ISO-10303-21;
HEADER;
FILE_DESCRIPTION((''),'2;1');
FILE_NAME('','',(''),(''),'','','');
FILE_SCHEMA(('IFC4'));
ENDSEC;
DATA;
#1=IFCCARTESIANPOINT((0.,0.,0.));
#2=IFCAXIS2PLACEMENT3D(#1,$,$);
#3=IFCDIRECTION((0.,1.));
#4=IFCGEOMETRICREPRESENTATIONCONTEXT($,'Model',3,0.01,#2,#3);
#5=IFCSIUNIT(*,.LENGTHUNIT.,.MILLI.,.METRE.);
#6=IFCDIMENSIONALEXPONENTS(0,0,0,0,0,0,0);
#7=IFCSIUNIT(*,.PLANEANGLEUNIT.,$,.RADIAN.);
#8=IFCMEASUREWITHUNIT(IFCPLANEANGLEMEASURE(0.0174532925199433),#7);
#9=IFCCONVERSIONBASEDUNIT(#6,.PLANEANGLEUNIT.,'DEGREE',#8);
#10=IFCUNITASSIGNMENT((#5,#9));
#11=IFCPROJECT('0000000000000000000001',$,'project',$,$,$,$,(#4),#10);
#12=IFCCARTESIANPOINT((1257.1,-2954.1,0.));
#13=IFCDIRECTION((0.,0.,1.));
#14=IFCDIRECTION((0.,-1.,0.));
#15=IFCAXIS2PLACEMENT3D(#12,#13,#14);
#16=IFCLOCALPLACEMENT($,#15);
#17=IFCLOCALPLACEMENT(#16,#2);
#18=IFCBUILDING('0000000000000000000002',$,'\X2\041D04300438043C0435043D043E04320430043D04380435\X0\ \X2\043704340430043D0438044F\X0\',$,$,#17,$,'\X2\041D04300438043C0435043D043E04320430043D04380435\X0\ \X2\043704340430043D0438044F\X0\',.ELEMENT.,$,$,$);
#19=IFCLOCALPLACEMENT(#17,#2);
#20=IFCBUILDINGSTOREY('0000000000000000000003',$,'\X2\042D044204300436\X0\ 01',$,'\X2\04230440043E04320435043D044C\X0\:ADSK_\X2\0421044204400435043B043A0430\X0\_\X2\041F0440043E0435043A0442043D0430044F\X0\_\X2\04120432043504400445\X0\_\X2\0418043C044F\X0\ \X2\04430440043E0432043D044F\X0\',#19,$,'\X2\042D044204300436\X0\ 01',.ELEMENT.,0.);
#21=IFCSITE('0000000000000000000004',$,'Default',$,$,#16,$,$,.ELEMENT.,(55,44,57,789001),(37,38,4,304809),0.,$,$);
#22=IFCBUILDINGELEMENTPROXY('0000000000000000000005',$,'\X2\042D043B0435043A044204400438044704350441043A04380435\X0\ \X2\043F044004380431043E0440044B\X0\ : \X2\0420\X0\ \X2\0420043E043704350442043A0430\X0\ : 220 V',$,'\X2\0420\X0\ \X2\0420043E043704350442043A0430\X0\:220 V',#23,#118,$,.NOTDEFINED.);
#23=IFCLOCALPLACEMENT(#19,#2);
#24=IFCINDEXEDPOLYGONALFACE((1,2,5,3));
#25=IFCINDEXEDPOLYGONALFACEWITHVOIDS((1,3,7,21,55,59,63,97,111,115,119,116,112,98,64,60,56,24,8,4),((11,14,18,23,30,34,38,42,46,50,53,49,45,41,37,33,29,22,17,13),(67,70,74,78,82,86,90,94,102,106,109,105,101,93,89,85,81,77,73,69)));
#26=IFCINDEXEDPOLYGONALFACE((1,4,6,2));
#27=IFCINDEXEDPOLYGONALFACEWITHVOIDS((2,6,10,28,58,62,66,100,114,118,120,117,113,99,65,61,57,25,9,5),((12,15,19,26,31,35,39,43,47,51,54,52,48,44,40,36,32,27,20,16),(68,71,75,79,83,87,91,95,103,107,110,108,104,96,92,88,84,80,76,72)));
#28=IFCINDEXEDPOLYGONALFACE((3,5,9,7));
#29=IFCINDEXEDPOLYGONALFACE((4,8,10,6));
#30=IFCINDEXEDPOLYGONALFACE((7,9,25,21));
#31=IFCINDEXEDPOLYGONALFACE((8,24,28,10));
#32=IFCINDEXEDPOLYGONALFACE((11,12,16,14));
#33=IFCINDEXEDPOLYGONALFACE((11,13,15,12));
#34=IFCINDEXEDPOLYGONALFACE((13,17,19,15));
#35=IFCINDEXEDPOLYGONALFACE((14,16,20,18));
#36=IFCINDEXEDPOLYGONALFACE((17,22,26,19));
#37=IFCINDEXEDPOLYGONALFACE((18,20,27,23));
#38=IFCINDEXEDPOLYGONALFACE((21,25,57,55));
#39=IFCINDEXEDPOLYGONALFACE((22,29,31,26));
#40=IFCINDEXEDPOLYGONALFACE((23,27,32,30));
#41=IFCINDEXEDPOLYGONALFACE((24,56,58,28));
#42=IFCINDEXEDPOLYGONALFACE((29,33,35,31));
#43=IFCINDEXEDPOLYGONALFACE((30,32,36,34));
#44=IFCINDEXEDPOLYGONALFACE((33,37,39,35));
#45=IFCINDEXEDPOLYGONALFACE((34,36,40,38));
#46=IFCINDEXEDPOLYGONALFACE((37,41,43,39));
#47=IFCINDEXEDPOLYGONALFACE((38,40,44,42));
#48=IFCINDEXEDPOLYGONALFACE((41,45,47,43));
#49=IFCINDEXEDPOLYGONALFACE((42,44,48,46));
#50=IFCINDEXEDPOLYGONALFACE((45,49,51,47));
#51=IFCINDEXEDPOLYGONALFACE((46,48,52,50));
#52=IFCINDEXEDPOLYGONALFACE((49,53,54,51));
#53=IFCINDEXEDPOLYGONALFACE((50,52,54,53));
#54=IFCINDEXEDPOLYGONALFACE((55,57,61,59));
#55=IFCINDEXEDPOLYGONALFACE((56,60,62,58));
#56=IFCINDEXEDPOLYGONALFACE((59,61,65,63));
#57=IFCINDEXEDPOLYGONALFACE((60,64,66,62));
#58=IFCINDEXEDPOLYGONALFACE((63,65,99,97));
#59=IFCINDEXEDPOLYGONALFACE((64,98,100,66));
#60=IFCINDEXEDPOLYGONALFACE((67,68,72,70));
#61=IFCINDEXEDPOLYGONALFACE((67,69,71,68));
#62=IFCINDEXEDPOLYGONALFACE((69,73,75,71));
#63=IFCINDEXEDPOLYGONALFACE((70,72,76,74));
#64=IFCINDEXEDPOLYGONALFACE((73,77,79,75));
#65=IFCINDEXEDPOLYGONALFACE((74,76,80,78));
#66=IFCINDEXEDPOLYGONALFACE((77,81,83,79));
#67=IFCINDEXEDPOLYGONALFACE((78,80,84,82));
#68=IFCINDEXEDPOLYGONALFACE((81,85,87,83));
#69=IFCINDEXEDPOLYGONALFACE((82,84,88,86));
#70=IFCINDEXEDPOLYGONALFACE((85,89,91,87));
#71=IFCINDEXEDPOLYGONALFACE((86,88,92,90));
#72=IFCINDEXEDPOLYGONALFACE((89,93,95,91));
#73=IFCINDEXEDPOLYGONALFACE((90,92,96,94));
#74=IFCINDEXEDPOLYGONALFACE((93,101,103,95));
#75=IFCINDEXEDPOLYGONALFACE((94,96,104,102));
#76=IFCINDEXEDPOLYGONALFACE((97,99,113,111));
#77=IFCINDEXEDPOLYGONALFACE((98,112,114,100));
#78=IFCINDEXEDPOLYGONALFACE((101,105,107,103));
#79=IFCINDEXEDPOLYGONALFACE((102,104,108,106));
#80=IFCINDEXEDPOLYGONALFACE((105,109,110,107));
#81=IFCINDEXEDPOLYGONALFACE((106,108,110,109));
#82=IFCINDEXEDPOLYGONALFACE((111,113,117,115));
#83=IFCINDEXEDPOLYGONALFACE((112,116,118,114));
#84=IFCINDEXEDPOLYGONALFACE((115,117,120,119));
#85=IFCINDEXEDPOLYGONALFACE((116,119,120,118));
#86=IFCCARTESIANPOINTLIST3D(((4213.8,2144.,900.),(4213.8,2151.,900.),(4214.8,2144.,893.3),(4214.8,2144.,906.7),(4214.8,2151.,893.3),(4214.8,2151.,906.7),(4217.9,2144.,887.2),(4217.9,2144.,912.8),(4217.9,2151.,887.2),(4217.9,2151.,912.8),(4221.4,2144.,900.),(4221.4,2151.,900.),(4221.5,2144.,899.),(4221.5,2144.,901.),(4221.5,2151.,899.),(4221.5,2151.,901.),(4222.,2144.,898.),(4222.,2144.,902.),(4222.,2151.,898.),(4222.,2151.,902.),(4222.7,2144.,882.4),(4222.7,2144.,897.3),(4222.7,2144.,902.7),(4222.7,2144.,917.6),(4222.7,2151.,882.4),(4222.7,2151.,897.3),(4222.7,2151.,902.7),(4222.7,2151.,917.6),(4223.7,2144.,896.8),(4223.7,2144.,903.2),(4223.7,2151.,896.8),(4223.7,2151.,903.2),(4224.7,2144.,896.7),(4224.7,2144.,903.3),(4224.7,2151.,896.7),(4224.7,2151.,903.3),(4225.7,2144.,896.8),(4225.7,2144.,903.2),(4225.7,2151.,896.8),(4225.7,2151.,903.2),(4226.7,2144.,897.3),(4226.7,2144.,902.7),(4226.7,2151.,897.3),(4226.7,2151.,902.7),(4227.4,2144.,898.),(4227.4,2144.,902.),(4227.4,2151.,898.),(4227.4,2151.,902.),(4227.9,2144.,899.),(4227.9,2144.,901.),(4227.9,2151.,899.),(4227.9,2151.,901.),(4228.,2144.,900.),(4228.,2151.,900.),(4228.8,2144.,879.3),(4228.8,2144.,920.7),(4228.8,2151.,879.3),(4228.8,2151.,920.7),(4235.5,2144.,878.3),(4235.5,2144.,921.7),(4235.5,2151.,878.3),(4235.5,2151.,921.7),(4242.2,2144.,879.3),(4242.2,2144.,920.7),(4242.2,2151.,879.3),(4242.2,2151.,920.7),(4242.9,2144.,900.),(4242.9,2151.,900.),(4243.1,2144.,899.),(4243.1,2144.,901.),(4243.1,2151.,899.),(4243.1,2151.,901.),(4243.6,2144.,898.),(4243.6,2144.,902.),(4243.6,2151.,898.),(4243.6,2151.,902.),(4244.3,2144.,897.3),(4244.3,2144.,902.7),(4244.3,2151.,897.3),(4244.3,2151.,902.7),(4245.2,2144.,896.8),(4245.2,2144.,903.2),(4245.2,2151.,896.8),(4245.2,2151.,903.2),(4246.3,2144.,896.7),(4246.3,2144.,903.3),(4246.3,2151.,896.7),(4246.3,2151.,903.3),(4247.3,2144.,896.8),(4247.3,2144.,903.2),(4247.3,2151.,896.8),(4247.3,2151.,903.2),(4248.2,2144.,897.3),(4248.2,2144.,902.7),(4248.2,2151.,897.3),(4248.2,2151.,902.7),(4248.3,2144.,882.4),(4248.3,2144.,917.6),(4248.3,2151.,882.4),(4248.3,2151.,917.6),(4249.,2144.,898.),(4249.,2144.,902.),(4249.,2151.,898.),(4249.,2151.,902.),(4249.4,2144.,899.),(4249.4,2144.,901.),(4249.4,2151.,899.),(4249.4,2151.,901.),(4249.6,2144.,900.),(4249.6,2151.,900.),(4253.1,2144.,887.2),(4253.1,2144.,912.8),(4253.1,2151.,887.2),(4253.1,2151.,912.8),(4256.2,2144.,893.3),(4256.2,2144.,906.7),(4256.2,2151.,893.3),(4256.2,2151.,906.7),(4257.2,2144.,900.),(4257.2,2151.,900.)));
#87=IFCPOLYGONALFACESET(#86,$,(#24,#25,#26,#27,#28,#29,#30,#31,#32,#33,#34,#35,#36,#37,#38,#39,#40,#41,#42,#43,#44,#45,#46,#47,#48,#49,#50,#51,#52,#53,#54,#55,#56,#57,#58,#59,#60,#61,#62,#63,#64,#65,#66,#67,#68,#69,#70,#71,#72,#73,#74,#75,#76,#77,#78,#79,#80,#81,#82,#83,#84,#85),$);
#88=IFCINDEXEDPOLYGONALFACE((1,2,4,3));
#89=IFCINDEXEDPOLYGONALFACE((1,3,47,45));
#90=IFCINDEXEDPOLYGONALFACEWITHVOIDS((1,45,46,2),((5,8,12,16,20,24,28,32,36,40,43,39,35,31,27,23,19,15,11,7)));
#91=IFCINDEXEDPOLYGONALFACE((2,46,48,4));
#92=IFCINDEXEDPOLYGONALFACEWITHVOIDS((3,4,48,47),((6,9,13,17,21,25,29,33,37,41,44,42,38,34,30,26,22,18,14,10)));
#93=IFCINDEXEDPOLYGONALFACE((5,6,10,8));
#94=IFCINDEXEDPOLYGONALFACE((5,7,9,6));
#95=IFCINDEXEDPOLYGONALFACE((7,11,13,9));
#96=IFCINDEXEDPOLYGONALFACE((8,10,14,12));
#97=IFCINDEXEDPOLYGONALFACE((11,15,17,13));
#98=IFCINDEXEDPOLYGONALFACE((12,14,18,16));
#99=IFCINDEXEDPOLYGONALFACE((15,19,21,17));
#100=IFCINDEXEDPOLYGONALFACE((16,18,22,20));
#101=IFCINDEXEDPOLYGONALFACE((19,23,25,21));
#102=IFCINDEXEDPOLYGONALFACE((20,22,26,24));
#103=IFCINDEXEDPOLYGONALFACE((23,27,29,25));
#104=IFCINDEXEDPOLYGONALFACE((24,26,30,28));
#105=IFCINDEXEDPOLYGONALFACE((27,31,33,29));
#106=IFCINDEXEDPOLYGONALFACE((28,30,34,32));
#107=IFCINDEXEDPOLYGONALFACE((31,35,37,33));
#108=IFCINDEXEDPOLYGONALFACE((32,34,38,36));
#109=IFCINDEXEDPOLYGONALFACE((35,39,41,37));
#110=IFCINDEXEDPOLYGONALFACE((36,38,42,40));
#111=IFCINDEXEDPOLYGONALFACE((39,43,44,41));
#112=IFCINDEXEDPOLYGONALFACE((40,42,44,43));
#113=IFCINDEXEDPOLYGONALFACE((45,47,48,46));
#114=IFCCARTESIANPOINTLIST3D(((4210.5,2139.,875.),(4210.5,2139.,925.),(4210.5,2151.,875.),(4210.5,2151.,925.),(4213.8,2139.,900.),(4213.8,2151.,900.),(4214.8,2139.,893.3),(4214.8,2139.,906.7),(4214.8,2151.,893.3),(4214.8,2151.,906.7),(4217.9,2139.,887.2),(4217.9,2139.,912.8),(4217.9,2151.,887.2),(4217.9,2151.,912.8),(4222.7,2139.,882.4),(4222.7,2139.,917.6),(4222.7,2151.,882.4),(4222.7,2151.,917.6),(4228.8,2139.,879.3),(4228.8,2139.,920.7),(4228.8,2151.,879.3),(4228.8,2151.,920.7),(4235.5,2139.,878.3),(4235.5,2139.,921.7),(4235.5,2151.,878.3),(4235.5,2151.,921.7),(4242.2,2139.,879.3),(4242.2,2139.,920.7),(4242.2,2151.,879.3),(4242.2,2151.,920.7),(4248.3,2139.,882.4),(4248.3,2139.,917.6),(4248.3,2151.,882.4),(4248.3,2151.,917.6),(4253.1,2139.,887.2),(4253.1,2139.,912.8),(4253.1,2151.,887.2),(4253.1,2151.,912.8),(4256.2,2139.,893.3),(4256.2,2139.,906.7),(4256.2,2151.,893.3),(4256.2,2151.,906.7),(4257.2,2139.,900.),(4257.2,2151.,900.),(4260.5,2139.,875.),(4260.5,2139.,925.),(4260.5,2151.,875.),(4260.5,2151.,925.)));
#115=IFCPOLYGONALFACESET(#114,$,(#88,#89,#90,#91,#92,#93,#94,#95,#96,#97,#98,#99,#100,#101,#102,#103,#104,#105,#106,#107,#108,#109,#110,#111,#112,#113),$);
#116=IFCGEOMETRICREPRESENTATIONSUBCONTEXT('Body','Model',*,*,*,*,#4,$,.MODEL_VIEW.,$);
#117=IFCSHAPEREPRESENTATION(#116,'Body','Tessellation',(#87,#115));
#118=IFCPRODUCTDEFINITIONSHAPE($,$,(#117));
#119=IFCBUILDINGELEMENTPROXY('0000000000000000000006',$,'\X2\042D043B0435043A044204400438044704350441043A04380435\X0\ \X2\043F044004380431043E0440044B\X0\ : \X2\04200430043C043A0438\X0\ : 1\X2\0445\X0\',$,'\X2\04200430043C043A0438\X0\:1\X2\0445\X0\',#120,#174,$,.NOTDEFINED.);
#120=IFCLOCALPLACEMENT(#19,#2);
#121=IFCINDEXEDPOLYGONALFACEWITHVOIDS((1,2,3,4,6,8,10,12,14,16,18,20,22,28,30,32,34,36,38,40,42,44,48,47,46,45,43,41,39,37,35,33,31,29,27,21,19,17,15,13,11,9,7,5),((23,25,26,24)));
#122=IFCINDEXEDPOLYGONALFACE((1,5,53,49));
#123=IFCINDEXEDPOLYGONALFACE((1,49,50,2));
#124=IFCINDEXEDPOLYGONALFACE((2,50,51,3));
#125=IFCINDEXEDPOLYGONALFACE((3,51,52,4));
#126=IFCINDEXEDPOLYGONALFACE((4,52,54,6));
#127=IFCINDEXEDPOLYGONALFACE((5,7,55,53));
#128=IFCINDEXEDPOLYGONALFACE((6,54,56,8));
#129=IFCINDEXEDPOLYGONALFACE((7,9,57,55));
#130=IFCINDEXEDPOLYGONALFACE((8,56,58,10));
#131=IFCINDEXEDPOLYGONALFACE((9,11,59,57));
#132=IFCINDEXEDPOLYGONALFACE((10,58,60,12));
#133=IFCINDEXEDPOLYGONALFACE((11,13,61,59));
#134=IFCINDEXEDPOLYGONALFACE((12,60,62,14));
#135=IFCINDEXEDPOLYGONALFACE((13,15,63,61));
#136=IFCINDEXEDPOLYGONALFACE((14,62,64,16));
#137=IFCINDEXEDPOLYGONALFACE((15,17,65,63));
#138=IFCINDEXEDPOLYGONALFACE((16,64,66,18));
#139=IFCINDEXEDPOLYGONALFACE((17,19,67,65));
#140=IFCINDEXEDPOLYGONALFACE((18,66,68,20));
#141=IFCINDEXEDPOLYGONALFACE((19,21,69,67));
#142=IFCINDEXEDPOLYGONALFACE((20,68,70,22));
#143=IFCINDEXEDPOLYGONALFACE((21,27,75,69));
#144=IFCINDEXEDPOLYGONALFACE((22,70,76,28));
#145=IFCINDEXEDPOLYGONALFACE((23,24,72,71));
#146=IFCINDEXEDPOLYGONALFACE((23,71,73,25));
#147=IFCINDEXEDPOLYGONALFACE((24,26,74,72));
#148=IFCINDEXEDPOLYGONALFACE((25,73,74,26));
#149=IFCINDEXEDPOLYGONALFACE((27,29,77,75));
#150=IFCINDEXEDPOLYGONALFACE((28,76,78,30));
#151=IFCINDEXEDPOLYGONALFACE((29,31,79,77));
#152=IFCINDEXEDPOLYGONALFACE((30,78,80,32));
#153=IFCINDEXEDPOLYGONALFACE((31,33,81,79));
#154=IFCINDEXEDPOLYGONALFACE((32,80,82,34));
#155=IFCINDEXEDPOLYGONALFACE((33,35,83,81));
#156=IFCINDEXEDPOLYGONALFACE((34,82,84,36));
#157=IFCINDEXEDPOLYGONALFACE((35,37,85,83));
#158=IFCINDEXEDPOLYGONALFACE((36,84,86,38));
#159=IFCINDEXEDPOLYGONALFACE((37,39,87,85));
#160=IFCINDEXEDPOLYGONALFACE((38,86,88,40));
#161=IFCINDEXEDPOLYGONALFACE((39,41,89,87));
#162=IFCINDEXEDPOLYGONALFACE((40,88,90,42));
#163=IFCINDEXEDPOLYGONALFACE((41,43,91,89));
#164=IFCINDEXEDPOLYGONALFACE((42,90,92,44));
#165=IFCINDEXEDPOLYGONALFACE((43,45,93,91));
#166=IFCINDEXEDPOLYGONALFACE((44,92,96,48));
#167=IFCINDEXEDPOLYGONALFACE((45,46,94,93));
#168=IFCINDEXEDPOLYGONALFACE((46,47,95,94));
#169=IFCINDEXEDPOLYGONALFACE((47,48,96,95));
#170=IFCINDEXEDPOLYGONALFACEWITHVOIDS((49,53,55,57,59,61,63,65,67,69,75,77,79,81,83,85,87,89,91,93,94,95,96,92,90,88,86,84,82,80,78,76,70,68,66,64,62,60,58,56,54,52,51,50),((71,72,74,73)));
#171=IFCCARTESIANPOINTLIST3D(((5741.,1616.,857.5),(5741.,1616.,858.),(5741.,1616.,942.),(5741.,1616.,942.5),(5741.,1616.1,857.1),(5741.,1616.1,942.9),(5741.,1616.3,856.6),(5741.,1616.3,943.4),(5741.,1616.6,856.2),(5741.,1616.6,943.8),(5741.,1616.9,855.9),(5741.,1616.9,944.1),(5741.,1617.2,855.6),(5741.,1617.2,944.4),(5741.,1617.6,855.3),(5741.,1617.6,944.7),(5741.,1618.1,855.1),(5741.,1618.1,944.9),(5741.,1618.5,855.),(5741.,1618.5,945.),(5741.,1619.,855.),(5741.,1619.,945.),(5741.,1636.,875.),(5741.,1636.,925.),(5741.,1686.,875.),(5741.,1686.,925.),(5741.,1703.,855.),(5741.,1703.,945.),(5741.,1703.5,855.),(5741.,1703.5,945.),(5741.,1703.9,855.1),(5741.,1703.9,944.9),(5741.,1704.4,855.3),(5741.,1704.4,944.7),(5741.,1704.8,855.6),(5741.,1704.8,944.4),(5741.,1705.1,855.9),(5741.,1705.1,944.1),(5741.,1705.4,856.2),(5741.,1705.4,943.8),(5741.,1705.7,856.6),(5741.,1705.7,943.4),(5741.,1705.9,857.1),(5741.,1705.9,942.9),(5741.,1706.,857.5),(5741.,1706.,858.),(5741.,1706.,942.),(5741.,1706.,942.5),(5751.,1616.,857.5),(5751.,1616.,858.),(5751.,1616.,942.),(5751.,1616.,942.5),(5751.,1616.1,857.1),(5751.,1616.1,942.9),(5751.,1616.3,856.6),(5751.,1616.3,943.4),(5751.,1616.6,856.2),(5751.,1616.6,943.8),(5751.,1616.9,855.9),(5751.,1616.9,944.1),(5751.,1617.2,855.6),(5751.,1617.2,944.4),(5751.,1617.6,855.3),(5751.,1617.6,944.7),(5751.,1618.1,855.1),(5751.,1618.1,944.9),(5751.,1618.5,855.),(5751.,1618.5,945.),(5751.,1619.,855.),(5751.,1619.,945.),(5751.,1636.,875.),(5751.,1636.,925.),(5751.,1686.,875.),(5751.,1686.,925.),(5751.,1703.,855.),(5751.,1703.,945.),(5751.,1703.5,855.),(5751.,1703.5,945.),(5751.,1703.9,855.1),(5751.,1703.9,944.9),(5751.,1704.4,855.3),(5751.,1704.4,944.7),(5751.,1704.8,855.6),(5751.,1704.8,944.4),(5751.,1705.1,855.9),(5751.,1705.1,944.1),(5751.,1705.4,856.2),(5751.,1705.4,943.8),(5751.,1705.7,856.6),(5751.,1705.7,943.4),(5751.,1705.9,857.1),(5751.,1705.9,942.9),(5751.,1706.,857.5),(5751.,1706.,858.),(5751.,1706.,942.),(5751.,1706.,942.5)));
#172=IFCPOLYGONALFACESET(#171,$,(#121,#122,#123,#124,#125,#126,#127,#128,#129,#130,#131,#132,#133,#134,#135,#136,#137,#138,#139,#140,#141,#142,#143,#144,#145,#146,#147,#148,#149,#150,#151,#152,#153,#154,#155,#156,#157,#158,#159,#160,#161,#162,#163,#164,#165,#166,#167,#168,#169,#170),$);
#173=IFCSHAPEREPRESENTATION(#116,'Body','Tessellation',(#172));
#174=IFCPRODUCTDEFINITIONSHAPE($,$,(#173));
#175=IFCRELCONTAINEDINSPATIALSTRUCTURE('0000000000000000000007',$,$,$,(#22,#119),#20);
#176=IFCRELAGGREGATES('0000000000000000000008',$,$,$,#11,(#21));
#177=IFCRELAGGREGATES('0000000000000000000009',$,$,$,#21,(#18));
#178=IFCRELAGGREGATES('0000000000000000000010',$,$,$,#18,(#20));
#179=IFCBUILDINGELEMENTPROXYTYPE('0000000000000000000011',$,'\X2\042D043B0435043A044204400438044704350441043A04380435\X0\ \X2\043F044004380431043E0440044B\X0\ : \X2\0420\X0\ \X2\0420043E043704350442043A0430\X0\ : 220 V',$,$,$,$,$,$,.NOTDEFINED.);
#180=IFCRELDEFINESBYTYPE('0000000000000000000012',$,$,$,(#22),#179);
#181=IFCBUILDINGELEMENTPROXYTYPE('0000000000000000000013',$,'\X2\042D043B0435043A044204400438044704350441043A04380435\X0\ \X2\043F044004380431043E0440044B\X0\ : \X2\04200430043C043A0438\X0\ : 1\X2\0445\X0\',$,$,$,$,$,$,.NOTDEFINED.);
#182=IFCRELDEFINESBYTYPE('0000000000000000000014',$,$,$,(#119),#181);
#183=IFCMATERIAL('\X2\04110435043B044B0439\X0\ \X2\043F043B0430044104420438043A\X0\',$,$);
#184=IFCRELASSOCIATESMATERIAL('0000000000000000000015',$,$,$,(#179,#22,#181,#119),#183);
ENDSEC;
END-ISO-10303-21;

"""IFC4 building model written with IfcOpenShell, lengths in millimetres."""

from ifc_helpers import new_model, entity, si_unit, converted_unit, direction, frame, origin, place, context, subcontext, project, spatial, indexed_curve, outline, extrude, source, transform, mapped, material, type_object, type_shapes, element, save


model = new_model("IFC4")

# Units and contexts
model_context = context("Model", 3, precision=0.01, world=origin(), true_north=direction((0.0, 1.0)))
body_context = subcontext(model_context, "Body", "Model", "MODEL_VIEW")
ifc_project = project(units=[si_unit("LENGTHUNIT", "METRE", prefix="MILLI"), converted_unit("PLANEANGLEUNIT", "DEGREE", entity("IfcPlaneAngleMeasure", 0.0174532925199433), si_unit("PLANEANGLEUNIT", "RADIAN"), dimensions=[0, 0, 0, 0, 0, 0, 0])], contexts=[model_context])

# Site, building, storey
site_placement = place(None, frame((1257.1, -2954.1, 0.0), z_axis=(0.0, 0.0, 1.0), x_axis=(0.0, -1.0, 0.0)))
site = spatial("IfcSite", under=ifc_project, at=site_placement, Name="Default", CompositionType="ELEMENT", RefLatitude=(55, 44, 57, 789001), RefLongitude=(37, 38, 4, 304809), RefElevation=0.0)
building_placement = place(site_placement, origin())
building = spatial("IfcBuilding", under=site, at=building_placement, Name="Наименование здания", LongName="Наименование здания", CompositionType="ELEMENT")
storey_placement = place(building_placement, origin())
storey = spatial("IfcBuildingStorey", under=building, at=storey_placement, Name="Этаж 01", ObjectType="Уровень:ADSK_Стрелка_Проектная_Вверх_Имя уровня", LongName="Этаж 01", CompositionType="ELEMENT", Elevation=0.0)

# Building element proxies
ifc_material_1 = material(Name="Белый пластик")
building_element_proxy_type_1 = type_object("IfcBuildingElementProxyType", Name="Электрические приборы : Р Розетка : 220 V", PredefinedType="NOTDEFINED", material=ifc_material_1)
shared_shape_1 = source(origin(), body_context, "Body", "SweptSolid", [
    extrude(outline(indexed_curve([(21.7, 0.0), (20.7, 6.7), (17.6, 12.8), (12.8, 17.6), (6.7, 20.7), (0.0, 21.7), (-6.7, 20.7), (-12.8, 17.6), (-17.6, 12.8), (-20.7, 6.7), (-21.7, 0.0), (-20.7, -6.7), (-17.6, -12.8), (-12.8, -17.6), (-6.7, -20.7), (0.0, -21.7), (6.7, -20.7), (12.8, -17.6), (17.6, -12.8), (20.7, -6.7), (21.7, 0.0)], self_intersect=False), holes=[indexed_curve([(-7.5, 0.0), (-7.6, -1.0), (-8.1, -2.0), (-8.8, -2.7), (-9.8, -3.2), (-10.8, -3.3), (-11.8, -3.2), (-12.8, -2.7), (-13.5, -2.0), (-14.0, -1.0), (-14.1, 0.0), (-14.0, 1.0), (-13.5, 2.0), (-12.8, 2.7), (-11.8, 3.2), (-10.8, 3.3), (-9.8, 3.2), (-8.8, 2.7), (-8.1, 2.0), (-7.6, 1.0), (-7.5, 0.0)], self_intersect=False), indexed_curve([(14.1, 0.0), (13.9, -1.0), (13.5, -2.0), (12.7, -2.7), (11.8, -3.2), (10.8, -3.3), (9.7, -3.2), (8.8, -2.7), (8.1, -2.0), (7.6, -1.0), (7.4, 0.0), (7.6, 1.0), (8.1, 2.0), (8.8, 2.7), (9.7, 3.2), (10.8, 3.3), (11.8, 3.2), (12.7, 2.7), (13.5, 2.0), (13.9, 1.0), (14.1, 0.0)], self_intersect=False)]), frame((374.3, -712.5, 0.0)), (0.0, 0.0, 1.0), 7.0),
    extrude(outline(indexed_curve([(-25.0, -25.0), (25.0, -25.0), (25.0, 25.0), (-25.0, 25.0), (-25.0, -25.0)], self_intersect=False), holes=[indexed_curve([(-21.7, 0.0), (-20.7, 6.7), (-17.6, 12.8), (-12.8, 17.6), (-6.7, 20.7), (0.0, 21.7), (6.7, 20.7), (12.8, 17.6), (17.6, 12.8), (20.7, 6.7), (21.7, 0.0), (20.7, -6.7), (17.6, -12.8), (12.8, -17.6), (6.7, -20.7), (0.0, -21.7), (-6.7, -20.7), (-12.8, -17.6), (-17.6, -12.8), (-20.7, -6.7), (-21.7, 0.0)], self_intersect=False)]), frame((374.3, -712.5, 0.0), z_axis=(0.0, 0.0, 1.0), x_axis=(-1.0, 0.0, 0.0)), (0.0, 0.0, 1.0), 12.0),
])
type_shapes(building_element_proxy_type_1, [shared_shape_1])
for number, where, z_axis, x_axis, name in (
    (1, (3861.2, 2151.0, 1612.5), (0.0, -1.0, 0.0), (1.0, 0.0, 0.0), "Электрические приборы : Р Розетка : 220 V"),
):
    element("IfcBuildingElementProxy", number, at=place(storey_placement, frame(where, z_axis=z_axis, x_axis=x_axis)), inside=storey, type_object=building_element_proxy_type_1, material=ifc_material_1, Name=name, ObjectType="Р Розетка:220 V", PredefinedType="NOTDEFINED", context=body_context, shape_type="MappedRepresentation", body=[
        mapped(shared_shape_1, transform((0.0, 0.0, 0.0), scale=1.0)),
    ])
building_element_proxy_type_2 = type_object("IfcBuildingElementProxyType", Name="Электрические приборы : Рамки : 1х", PredefinedType="NOTDEFINED", material=ifc_material_1)
shared_shape_2 = source(origin(), body_context, "Body", "SweptSolid", [
    extrude(outline(indexed_curve([(-42.0, 45.0), (-42.5, 45.0), (-42.9, 44.9), (-43.4, 44.7), (-43.8, 44.4), (-44.1, 44.1), (-44.4, 43.8), (-44.7, 43.4), (-44.9, 42.9), (-45.0, 42.5), (-45.0, 42.0), (-45.0, -42.0), (-45.0, -42.5), (-44.9, -42.9), (-44.7, -43.4), (-44.4, -43.8), (-44.1, -44.1), (-43.8, -44.4), (-43.4, -44.7), (-42.9, -44.9), (-42.5, -45.0), (-42.0, -45.0), (42.0, -45.0), (42.5, -45.0), (42.9, -44.9), (43.4, -44.7), (43.8, -44.4), (44.1, -44.1), (44.4, -43.8), (44.7, -43.4), (44.9, -42.9), (45.0, -42.5), (45.0, -42.0), (45.0, 42.0), (45.0, 42.5), (44.9, 42.9), (44.7, 43.4), (44.4, 43.8), (44.1, 44.1), (43.8, 44.4), (43.4, 44.7), (42.9, 44.9), (42.5, 45.0), (42.0, 45.0), (-42.0, 45.0)], self_intersect=False), holes=[indexed_curve([(-25.0, 25.0), (25.0, 25.0), (25.0, -25.0), (-25.0, -25.0), (-25.0, 25.0)], self_intersect=False)]), origin(), (0.0, 0.0, 1.0), 10.0),
])
type_shapes(building_element_proxy_type_2, [shared_shape_2])
proxy_1_placement = place(storey_placement, frame((5751.0, 1661.0, 900.0), z_axis=(-1.0, 0.0, 0.0), x_axis=(0.0, -1.0, 0.0)))
element("IfcBuildingElementProxy", 2, at=proxy_1_placement, inside=storey, type_object=building_element_proxy_type_2, material=ifc_material_1, Name="Электрические приборы : Рамки : 1х", ObjectType="Рамки:1х", PredefinedType="NOTDEFINED", context=body_context, shape_type="MappedRepresentation", body=[
    mapped(shared_shape_2, transform((0.0, 0.0, 0.0), scale=1.0)),
])

save(model, "model.ifc")
